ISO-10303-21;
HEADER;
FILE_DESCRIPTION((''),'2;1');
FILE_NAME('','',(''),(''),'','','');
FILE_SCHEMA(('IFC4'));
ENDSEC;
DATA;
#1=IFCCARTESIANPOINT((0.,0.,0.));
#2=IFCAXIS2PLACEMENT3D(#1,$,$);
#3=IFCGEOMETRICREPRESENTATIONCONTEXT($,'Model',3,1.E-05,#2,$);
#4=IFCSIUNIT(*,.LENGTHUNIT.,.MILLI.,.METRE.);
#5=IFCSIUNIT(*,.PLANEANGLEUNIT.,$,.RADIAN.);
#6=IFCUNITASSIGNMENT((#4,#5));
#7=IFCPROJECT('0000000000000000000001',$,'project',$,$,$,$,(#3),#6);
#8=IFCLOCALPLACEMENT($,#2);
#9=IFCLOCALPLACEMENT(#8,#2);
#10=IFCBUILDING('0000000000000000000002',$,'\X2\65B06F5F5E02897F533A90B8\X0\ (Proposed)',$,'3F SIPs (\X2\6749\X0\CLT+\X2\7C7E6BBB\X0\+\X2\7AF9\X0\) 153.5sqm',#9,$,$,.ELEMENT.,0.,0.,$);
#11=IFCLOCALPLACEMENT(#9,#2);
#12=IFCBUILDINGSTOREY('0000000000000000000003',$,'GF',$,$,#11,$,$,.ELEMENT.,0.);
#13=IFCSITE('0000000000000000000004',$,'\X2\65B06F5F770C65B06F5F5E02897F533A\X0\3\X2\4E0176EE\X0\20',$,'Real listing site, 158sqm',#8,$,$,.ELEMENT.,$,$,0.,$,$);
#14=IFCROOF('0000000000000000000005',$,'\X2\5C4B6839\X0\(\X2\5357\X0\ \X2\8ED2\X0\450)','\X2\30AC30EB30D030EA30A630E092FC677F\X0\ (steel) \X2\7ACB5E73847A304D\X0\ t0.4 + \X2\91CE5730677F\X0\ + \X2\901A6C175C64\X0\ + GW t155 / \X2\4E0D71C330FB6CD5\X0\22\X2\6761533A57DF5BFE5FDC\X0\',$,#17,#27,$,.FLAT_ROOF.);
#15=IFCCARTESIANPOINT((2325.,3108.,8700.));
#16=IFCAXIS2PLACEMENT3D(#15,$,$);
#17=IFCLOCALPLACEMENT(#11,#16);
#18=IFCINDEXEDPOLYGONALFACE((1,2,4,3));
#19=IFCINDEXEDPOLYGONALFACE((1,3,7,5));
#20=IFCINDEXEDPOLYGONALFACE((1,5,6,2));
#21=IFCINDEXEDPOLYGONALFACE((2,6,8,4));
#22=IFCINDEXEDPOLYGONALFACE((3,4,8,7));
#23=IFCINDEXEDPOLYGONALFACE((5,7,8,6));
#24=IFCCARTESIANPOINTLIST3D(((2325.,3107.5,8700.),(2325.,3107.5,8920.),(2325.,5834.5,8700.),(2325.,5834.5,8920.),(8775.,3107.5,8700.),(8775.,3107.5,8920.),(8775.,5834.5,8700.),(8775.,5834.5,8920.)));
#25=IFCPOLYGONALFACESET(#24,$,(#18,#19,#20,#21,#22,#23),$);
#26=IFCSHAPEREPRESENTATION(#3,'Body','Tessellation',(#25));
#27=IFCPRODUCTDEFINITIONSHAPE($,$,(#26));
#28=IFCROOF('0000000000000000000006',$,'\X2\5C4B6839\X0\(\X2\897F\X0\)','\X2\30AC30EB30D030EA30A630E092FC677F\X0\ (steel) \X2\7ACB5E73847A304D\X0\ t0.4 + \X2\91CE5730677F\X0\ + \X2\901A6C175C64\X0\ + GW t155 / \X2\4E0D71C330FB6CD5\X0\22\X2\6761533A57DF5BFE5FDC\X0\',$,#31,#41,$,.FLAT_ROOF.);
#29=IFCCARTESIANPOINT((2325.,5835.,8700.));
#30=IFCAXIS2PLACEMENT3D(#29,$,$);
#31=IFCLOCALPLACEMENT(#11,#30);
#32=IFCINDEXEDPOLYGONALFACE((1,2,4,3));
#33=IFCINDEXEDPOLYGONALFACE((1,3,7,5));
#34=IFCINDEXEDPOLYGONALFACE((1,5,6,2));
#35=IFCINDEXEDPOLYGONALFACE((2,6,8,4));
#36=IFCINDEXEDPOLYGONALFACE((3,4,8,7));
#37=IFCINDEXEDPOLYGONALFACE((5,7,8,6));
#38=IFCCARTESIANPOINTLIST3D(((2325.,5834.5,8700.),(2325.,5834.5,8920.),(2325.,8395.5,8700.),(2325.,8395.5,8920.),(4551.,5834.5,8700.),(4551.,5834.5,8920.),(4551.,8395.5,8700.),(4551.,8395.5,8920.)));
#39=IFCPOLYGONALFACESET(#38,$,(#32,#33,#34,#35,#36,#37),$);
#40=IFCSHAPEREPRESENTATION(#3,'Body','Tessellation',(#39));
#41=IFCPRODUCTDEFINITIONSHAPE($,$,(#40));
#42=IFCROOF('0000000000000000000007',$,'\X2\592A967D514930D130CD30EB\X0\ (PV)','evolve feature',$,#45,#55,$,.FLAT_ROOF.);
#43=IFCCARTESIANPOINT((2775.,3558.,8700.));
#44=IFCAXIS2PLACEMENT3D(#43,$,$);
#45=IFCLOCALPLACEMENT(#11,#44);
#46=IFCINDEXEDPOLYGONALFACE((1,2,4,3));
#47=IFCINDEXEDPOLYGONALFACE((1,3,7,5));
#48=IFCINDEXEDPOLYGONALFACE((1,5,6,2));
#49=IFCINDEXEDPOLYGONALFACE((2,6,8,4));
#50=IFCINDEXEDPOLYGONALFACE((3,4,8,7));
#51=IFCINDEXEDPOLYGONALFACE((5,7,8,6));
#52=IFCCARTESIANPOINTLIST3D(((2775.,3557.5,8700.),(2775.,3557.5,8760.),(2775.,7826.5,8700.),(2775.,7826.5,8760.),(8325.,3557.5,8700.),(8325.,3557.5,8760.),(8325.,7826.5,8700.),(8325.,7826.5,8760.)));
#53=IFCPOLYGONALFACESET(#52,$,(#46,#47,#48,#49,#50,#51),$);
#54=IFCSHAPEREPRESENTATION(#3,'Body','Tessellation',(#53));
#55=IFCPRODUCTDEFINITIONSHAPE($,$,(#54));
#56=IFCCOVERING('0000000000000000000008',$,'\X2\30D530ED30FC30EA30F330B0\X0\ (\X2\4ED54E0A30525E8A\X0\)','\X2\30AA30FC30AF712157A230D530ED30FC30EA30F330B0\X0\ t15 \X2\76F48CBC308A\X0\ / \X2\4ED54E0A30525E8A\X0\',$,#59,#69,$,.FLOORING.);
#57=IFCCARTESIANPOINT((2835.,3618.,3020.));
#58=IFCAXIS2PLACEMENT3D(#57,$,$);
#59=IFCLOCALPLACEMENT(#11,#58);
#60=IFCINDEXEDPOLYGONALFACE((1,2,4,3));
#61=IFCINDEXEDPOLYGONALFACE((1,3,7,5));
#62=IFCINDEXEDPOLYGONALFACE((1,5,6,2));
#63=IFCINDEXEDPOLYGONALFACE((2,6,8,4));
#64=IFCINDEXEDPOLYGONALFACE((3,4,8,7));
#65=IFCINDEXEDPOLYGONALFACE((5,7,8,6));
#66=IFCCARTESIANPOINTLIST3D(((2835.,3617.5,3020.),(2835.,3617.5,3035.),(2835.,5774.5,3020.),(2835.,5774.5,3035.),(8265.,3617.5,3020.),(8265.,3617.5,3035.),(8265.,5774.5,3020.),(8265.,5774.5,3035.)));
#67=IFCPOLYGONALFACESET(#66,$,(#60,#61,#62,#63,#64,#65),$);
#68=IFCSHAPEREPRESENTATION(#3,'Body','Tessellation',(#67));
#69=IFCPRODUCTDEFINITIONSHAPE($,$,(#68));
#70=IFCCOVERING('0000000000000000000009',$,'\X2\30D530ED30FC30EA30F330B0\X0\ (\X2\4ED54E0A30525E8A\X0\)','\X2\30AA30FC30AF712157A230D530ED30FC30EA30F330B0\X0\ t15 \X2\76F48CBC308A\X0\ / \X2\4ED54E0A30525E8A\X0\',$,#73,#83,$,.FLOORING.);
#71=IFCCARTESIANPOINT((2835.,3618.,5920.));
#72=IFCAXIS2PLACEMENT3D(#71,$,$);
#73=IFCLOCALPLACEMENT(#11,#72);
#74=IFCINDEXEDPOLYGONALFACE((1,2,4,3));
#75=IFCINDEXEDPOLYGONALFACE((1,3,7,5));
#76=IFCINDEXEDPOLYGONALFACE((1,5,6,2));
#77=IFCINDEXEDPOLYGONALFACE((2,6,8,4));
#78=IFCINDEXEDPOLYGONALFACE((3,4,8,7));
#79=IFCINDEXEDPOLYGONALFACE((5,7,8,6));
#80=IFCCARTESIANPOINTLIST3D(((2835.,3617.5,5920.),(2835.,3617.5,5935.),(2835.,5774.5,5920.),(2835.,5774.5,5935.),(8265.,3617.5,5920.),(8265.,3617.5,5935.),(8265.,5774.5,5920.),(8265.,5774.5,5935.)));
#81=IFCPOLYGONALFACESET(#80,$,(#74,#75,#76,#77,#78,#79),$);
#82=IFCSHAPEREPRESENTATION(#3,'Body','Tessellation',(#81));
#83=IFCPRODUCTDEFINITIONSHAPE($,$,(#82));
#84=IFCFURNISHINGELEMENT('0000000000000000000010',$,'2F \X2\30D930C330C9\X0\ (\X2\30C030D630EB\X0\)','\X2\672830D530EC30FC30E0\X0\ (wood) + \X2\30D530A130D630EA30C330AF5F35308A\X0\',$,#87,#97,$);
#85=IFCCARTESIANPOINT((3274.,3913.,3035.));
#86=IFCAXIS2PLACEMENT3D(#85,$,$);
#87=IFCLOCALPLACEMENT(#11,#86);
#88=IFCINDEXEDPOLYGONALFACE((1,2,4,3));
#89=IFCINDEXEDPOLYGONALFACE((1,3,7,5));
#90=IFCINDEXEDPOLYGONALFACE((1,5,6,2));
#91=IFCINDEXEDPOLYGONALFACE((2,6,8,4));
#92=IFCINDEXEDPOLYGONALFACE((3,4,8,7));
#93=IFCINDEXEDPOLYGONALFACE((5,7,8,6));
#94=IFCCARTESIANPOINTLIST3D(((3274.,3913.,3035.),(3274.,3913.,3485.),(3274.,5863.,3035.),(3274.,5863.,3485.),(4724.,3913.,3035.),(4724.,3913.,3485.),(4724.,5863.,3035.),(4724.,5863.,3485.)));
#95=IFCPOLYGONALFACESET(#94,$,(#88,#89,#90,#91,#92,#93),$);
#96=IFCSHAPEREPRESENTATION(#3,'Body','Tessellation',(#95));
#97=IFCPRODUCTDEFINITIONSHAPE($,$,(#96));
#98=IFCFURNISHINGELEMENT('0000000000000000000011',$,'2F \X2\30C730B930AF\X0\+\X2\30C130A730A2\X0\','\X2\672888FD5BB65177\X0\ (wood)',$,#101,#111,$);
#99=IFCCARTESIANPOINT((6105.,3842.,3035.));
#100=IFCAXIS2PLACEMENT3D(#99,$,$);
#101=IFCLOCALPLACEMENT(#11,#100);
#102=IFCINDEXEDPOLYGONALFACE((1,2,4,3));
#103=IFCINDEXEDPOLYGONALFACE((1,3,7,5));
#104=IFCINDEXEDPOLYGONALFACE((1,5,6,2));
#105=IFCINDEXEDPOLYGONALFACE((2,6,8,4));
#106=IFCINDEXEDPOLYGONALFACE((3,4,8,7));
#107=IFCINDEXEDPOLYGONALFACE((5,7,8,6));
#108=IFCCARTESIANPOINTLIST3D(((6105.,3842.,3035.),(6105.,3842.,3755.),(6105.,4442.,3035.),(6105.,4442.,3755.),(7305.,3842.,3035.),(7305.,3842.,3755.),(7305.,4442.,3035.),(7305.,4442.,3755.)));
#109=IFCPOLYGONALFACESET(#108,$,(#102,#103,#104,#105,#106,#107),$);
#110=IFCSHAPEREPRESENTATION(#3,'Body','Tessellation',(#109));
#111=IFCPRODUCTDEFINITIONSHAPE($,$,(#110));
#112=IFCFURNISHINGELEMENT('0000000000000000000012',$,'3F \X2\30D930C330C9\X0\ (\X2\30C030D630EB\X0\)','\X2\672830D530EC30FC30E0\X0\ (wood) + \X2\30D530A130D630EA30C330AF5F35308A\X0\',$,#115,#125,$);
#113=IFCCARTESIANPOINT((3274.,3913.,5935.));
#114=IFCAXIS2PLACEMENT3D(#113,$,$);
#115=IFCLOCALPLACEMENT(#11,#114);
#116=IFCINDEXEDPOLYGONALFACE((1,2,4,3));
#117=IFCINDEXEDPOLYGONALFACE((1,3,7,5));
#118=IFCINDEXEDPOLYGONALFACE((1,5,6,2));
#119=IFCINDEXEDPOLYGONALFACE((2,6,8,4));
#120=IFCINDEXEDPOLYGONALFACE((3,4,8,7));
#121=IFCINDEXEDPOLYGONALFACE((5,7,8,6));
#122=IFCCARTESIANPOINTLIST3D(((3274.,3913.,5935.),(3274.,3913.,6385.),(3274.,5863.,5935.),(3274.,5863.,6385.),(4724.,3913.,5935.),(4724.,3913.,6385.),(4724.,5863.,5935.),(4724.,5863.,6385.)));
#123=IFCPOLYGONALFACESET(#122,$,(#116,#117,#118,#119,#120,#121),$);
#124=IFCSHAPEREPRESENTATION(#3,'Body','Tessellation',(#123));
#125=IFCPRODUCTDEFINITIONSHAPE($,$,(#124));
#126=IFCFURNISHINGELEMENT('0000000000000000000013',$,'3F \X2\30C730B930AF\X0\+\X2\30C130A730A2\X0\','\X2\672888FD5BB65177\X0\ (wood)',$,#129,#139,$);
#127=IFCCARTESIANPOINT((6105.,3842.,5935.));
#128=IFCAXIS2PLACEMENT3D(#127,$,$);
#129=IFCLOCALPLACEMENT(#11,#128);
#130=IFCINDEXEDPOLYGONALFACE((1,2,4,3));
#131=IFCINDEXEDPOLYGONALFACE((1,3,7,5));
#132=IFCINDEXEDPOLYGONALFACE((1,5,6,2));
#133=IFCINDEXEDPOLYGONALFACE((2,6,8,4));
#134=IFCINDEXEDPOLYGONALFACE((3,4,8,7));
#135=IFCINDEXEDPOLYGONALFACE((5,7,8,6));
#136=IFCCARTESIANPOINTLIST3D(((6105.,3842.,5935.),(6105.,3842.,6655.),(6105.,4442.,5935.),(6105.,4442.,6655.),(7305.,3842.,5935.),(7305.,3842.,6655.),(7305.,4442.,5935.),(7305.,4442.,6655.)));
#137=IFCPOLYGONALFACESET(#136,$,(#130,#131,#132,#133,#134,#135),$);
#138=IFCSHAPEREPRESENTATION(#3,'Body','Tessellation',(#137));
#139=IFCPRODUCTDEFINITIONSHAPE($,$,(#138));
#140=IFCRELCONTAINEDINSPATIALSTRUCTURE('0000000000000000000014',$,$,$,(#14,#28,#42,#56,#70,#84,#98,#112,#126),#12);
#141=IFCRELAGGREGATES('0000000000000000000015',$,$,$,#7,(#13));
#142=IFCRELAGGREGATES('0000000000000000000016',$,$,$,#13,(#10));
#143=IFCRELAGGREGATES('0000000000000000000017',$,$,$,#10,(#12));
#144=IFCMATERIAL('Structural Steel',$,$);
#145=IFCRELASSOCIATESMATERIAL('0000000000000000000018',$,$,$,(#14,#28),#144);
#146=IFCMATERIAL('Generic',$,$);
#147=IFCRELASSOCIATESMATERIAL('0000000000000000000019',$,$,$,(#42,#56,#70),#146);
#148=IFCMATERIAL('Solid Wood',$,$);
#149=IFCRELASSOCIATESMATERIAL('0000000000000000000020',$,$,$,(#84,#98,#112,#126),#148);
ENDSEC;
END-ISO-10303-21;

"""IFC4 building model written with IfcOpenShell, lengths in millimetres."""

from ifc_helpers import new_model, si_unit, frame, frame_2d, origin, place, context, project, spatial, rectangle, extrude, material, element, save


model = new_model("IFC4")

# Units and contexts
model_context = context("Model", 3, precision=1e-05, world=origin())
ifc_project = project(units=[si_unit("LENGTHUNIT", "METRE", prefix="MILLI"), si_unit("PLANEANGLEUNIT", "RADIAN")], contexts=[model_context])

# Site, building, storey
site_placement = place(None, origin())
site = spatial("IfcSite", under=ifc_project, at=site_placement, Name="新潟県新潟市西区3丁目20", ObjectType="Real listing site, 158sqm", CompositionType="ELEMENT", RefElevation=0.0)
building_placement = place(site_placement, origin())
building = spatial("IfcBuilding", under=site, at=building_placement, Name="新潟市西区邸 (Proposed)", ObjectType="3F SIPs (杉CLT+籾殻+竹) 153.5sqm", CompositionType="ELEMENT", ElevationOfRefHeight=0.0, ElevationOfTerrain=0.0)
storey_placement = place(building_placement, origin())
storey = spatial("IfcBuildingStorey", under=building, at=storey_placement, Name="GF", CompositionType="ELEMENT", Elevation=0.0)

# Shared definitions
ifc_material_1 = material(Name="Solid Wood")

# Roofs
ifc_material_2 = material(Name="Structural Steel")
roof_1_placement = place(storey_placement, frame((2325.0, 3108.0, 8700.0)))
element("IfcRoof", 1, at=roof_1_placement, inside=storey, material=ifc_material_2, Name="屋根(南 軒450)", Description="ガルバリウム鋼板 (steel) 立平葺き t0.4 + 野地板 + 通気層 + GW t155 / 不燃・法22条区域対応", PredefinedType="FLAT_ROOF", context=model_context, shape_type="SweptSolid", body=[
    extrude(rectangle(XDim=6450.0, YDim=2727.0, at=frame_2d((3225.0, 1363.0))), frame((2325.0, 3108.0, 8700.0)), (0.0, 0.0, 1.0), 220.0),
])
roof_2_placement = place(storey_placement, frame((2325.0, 5835.0, 8700.0)))
element("IfcRoof", 2, at=roof_2_placement, inside=storey, material=ifc_material_2, Name="屋根(西)", Description="ガルバリウム鋼板 (steel) 立平葺き t0.4 + 野地板 + 通気層 + GW t155 / 不燃・法22条区域対応", PredefinedType="FLAT_ROOF", context=model_context, shape_type="SweptSolid", body=[
    extrude(rectangle(XDim=2226.0, YDim=2561.0, at=frame_2d((1113.0, 1280.0))), frame((2325.0, 5835.0, 8700.0)), (0.0, 0.0, 1.0), 220.0),
])
ifc_material_3 = material(Name="Generic")
roof_3_placement = place(storey_placement, frame((2775.0, 3558.0, 8700.0)))
element("IfcRoof", 3, at=roof_3_placement, inside=storey, material=ifc_material_3, Name="太陽光パネル (PV)", Description="evolve feature", PredefinedType="FLAT_ROOF", context=model_context, shape_type="SweptSolid", body=[
    extrude(rectangle(XDim=5550.0, YDim=4269.0, at=frame_2d((2775.0, 2134.0))), frame((2775.0, 3558.0, 8700.0)), (0.0, 0.0, 1.0), 60.0),
])

# Coverings
covering_1_placement = place(storey_placement, frame((2835.0, 3618.0, 3020.0)))
element("IfcCovering", 4, at=covering_1_placement, inside=storey, material=ifc_material_3, Name="フローリング (仕上げ床)", Description="オーク無垢フローリング t15 直貼り / 仕上げ床", PredefinedType="FLOORING", context=model_context, shape_type="SweptSolid", body=[
    extrude(rectangle(XDim=5430.0, YDim=2157.0, at=frame_2d((2715.0, 1078.0))), frame((2835.0, 3618.0, 3020.0)), (0.0, 0.0, 1.0), 15.0),
])
covering_2_placement = place(storey_placement, frame((2835.0, 3618.0, 5920.0)))
element("IfcCovering", 5, at=covering_2_placement, inside=storey, material=ifc_material_3, Name="フローリング (仕上げ床)", Description="オーク無垢フローリング t15 直貼り / 仕上げ床", PredefinedType="FLOORING", context=model_context, shape_type="SweptSolid", body=[
    extrude(rectangle(XDim=5430.0, YDim=2157.0, at=frame_2d((2715.0, 1078.0))), frame((2835.0, 3618.0, 5920.0)), (0.0, 0.0, 1.0), 15.0),
])

# Furnishing elements
furnishing_1_placement = place(storey_placement, frame((3274.0, 3913.0, 3035.0)))
element("IfcFurnishingElement", 6, at=furnishing_1_placement, inside=storey, material=ifc_material_1, Name="2F ベッド (ダブル)", Description="木フレーム (wood) + ファブリック張り", context=model_context, shape_type="SweptSolid", body=[
    extrude(rectangle(XDim=1450.0, YDim=1950.0, at=frame_2d((725.0, 975.0))), frame((3274.0, 3913.0, 3035.0)), (0.0, 0.0, 1.0), 450.0),
])
furnishing_2_placement = place(storey_placement, frame((6105.0, 3842.0, 3035.0)))
element("IfcFurnishingElement", 7, at=furnishing_2_placement, inside=storey, material=ifc_material_1, Name="2F デスク+チェア", Description="木製家具 (wood)", context=model_context, shape_type="SweptSolid", body=[
    extrude(rectangle(XDim=1200.0, YDim=600.0, at=frame_2d((600.0, 300.0))), frame((6105.0, 3842.0, 3035.0)), (0.0, 0.0, 1.0), 720.0),
])
furnishing_3_placement = place(storey_placement, frame((3274.0, 3913.0, 5935.0)))
element("IfcFurnishingElement", 8, at=furnishing_3_placement, inside=storey, material=ifc_material_1, Name="3F ベッド (ダブル)", Description="木フレーム (wood) + ファブリック張り", context=model_context, shape_type="SweptSolid", body=[
    extrude(rectangle(XDim=1450.0, YDim=1950.0, at=frame_2d((725.0, 975.0))), frame((3274.0, 3913.0, 5935.0)), (0.0, 0.0, 1.0), 450.0),
])
furnishing_4_placement = place(storey_placement, frame((6105.0, 3842.0, 5935.0)))
element("IfcFurnishingElement", 9, at=furnishing_4_placement, inside=storey, material=ifc_material_1, Name="3F デスク+チェア", Description="木製家具 (wood)", context=model_context, shape_type="SweptSolid", body=[
    extrude(rectangle(XDim=1200.0, YDim=600.0, at=frame_2d((600.0, 300.0))), frame((6105.0, 3842.0, 5935.0)), (0.0, 0.0, 1.0), 720.0),
])

save(model, "model.ifc")
